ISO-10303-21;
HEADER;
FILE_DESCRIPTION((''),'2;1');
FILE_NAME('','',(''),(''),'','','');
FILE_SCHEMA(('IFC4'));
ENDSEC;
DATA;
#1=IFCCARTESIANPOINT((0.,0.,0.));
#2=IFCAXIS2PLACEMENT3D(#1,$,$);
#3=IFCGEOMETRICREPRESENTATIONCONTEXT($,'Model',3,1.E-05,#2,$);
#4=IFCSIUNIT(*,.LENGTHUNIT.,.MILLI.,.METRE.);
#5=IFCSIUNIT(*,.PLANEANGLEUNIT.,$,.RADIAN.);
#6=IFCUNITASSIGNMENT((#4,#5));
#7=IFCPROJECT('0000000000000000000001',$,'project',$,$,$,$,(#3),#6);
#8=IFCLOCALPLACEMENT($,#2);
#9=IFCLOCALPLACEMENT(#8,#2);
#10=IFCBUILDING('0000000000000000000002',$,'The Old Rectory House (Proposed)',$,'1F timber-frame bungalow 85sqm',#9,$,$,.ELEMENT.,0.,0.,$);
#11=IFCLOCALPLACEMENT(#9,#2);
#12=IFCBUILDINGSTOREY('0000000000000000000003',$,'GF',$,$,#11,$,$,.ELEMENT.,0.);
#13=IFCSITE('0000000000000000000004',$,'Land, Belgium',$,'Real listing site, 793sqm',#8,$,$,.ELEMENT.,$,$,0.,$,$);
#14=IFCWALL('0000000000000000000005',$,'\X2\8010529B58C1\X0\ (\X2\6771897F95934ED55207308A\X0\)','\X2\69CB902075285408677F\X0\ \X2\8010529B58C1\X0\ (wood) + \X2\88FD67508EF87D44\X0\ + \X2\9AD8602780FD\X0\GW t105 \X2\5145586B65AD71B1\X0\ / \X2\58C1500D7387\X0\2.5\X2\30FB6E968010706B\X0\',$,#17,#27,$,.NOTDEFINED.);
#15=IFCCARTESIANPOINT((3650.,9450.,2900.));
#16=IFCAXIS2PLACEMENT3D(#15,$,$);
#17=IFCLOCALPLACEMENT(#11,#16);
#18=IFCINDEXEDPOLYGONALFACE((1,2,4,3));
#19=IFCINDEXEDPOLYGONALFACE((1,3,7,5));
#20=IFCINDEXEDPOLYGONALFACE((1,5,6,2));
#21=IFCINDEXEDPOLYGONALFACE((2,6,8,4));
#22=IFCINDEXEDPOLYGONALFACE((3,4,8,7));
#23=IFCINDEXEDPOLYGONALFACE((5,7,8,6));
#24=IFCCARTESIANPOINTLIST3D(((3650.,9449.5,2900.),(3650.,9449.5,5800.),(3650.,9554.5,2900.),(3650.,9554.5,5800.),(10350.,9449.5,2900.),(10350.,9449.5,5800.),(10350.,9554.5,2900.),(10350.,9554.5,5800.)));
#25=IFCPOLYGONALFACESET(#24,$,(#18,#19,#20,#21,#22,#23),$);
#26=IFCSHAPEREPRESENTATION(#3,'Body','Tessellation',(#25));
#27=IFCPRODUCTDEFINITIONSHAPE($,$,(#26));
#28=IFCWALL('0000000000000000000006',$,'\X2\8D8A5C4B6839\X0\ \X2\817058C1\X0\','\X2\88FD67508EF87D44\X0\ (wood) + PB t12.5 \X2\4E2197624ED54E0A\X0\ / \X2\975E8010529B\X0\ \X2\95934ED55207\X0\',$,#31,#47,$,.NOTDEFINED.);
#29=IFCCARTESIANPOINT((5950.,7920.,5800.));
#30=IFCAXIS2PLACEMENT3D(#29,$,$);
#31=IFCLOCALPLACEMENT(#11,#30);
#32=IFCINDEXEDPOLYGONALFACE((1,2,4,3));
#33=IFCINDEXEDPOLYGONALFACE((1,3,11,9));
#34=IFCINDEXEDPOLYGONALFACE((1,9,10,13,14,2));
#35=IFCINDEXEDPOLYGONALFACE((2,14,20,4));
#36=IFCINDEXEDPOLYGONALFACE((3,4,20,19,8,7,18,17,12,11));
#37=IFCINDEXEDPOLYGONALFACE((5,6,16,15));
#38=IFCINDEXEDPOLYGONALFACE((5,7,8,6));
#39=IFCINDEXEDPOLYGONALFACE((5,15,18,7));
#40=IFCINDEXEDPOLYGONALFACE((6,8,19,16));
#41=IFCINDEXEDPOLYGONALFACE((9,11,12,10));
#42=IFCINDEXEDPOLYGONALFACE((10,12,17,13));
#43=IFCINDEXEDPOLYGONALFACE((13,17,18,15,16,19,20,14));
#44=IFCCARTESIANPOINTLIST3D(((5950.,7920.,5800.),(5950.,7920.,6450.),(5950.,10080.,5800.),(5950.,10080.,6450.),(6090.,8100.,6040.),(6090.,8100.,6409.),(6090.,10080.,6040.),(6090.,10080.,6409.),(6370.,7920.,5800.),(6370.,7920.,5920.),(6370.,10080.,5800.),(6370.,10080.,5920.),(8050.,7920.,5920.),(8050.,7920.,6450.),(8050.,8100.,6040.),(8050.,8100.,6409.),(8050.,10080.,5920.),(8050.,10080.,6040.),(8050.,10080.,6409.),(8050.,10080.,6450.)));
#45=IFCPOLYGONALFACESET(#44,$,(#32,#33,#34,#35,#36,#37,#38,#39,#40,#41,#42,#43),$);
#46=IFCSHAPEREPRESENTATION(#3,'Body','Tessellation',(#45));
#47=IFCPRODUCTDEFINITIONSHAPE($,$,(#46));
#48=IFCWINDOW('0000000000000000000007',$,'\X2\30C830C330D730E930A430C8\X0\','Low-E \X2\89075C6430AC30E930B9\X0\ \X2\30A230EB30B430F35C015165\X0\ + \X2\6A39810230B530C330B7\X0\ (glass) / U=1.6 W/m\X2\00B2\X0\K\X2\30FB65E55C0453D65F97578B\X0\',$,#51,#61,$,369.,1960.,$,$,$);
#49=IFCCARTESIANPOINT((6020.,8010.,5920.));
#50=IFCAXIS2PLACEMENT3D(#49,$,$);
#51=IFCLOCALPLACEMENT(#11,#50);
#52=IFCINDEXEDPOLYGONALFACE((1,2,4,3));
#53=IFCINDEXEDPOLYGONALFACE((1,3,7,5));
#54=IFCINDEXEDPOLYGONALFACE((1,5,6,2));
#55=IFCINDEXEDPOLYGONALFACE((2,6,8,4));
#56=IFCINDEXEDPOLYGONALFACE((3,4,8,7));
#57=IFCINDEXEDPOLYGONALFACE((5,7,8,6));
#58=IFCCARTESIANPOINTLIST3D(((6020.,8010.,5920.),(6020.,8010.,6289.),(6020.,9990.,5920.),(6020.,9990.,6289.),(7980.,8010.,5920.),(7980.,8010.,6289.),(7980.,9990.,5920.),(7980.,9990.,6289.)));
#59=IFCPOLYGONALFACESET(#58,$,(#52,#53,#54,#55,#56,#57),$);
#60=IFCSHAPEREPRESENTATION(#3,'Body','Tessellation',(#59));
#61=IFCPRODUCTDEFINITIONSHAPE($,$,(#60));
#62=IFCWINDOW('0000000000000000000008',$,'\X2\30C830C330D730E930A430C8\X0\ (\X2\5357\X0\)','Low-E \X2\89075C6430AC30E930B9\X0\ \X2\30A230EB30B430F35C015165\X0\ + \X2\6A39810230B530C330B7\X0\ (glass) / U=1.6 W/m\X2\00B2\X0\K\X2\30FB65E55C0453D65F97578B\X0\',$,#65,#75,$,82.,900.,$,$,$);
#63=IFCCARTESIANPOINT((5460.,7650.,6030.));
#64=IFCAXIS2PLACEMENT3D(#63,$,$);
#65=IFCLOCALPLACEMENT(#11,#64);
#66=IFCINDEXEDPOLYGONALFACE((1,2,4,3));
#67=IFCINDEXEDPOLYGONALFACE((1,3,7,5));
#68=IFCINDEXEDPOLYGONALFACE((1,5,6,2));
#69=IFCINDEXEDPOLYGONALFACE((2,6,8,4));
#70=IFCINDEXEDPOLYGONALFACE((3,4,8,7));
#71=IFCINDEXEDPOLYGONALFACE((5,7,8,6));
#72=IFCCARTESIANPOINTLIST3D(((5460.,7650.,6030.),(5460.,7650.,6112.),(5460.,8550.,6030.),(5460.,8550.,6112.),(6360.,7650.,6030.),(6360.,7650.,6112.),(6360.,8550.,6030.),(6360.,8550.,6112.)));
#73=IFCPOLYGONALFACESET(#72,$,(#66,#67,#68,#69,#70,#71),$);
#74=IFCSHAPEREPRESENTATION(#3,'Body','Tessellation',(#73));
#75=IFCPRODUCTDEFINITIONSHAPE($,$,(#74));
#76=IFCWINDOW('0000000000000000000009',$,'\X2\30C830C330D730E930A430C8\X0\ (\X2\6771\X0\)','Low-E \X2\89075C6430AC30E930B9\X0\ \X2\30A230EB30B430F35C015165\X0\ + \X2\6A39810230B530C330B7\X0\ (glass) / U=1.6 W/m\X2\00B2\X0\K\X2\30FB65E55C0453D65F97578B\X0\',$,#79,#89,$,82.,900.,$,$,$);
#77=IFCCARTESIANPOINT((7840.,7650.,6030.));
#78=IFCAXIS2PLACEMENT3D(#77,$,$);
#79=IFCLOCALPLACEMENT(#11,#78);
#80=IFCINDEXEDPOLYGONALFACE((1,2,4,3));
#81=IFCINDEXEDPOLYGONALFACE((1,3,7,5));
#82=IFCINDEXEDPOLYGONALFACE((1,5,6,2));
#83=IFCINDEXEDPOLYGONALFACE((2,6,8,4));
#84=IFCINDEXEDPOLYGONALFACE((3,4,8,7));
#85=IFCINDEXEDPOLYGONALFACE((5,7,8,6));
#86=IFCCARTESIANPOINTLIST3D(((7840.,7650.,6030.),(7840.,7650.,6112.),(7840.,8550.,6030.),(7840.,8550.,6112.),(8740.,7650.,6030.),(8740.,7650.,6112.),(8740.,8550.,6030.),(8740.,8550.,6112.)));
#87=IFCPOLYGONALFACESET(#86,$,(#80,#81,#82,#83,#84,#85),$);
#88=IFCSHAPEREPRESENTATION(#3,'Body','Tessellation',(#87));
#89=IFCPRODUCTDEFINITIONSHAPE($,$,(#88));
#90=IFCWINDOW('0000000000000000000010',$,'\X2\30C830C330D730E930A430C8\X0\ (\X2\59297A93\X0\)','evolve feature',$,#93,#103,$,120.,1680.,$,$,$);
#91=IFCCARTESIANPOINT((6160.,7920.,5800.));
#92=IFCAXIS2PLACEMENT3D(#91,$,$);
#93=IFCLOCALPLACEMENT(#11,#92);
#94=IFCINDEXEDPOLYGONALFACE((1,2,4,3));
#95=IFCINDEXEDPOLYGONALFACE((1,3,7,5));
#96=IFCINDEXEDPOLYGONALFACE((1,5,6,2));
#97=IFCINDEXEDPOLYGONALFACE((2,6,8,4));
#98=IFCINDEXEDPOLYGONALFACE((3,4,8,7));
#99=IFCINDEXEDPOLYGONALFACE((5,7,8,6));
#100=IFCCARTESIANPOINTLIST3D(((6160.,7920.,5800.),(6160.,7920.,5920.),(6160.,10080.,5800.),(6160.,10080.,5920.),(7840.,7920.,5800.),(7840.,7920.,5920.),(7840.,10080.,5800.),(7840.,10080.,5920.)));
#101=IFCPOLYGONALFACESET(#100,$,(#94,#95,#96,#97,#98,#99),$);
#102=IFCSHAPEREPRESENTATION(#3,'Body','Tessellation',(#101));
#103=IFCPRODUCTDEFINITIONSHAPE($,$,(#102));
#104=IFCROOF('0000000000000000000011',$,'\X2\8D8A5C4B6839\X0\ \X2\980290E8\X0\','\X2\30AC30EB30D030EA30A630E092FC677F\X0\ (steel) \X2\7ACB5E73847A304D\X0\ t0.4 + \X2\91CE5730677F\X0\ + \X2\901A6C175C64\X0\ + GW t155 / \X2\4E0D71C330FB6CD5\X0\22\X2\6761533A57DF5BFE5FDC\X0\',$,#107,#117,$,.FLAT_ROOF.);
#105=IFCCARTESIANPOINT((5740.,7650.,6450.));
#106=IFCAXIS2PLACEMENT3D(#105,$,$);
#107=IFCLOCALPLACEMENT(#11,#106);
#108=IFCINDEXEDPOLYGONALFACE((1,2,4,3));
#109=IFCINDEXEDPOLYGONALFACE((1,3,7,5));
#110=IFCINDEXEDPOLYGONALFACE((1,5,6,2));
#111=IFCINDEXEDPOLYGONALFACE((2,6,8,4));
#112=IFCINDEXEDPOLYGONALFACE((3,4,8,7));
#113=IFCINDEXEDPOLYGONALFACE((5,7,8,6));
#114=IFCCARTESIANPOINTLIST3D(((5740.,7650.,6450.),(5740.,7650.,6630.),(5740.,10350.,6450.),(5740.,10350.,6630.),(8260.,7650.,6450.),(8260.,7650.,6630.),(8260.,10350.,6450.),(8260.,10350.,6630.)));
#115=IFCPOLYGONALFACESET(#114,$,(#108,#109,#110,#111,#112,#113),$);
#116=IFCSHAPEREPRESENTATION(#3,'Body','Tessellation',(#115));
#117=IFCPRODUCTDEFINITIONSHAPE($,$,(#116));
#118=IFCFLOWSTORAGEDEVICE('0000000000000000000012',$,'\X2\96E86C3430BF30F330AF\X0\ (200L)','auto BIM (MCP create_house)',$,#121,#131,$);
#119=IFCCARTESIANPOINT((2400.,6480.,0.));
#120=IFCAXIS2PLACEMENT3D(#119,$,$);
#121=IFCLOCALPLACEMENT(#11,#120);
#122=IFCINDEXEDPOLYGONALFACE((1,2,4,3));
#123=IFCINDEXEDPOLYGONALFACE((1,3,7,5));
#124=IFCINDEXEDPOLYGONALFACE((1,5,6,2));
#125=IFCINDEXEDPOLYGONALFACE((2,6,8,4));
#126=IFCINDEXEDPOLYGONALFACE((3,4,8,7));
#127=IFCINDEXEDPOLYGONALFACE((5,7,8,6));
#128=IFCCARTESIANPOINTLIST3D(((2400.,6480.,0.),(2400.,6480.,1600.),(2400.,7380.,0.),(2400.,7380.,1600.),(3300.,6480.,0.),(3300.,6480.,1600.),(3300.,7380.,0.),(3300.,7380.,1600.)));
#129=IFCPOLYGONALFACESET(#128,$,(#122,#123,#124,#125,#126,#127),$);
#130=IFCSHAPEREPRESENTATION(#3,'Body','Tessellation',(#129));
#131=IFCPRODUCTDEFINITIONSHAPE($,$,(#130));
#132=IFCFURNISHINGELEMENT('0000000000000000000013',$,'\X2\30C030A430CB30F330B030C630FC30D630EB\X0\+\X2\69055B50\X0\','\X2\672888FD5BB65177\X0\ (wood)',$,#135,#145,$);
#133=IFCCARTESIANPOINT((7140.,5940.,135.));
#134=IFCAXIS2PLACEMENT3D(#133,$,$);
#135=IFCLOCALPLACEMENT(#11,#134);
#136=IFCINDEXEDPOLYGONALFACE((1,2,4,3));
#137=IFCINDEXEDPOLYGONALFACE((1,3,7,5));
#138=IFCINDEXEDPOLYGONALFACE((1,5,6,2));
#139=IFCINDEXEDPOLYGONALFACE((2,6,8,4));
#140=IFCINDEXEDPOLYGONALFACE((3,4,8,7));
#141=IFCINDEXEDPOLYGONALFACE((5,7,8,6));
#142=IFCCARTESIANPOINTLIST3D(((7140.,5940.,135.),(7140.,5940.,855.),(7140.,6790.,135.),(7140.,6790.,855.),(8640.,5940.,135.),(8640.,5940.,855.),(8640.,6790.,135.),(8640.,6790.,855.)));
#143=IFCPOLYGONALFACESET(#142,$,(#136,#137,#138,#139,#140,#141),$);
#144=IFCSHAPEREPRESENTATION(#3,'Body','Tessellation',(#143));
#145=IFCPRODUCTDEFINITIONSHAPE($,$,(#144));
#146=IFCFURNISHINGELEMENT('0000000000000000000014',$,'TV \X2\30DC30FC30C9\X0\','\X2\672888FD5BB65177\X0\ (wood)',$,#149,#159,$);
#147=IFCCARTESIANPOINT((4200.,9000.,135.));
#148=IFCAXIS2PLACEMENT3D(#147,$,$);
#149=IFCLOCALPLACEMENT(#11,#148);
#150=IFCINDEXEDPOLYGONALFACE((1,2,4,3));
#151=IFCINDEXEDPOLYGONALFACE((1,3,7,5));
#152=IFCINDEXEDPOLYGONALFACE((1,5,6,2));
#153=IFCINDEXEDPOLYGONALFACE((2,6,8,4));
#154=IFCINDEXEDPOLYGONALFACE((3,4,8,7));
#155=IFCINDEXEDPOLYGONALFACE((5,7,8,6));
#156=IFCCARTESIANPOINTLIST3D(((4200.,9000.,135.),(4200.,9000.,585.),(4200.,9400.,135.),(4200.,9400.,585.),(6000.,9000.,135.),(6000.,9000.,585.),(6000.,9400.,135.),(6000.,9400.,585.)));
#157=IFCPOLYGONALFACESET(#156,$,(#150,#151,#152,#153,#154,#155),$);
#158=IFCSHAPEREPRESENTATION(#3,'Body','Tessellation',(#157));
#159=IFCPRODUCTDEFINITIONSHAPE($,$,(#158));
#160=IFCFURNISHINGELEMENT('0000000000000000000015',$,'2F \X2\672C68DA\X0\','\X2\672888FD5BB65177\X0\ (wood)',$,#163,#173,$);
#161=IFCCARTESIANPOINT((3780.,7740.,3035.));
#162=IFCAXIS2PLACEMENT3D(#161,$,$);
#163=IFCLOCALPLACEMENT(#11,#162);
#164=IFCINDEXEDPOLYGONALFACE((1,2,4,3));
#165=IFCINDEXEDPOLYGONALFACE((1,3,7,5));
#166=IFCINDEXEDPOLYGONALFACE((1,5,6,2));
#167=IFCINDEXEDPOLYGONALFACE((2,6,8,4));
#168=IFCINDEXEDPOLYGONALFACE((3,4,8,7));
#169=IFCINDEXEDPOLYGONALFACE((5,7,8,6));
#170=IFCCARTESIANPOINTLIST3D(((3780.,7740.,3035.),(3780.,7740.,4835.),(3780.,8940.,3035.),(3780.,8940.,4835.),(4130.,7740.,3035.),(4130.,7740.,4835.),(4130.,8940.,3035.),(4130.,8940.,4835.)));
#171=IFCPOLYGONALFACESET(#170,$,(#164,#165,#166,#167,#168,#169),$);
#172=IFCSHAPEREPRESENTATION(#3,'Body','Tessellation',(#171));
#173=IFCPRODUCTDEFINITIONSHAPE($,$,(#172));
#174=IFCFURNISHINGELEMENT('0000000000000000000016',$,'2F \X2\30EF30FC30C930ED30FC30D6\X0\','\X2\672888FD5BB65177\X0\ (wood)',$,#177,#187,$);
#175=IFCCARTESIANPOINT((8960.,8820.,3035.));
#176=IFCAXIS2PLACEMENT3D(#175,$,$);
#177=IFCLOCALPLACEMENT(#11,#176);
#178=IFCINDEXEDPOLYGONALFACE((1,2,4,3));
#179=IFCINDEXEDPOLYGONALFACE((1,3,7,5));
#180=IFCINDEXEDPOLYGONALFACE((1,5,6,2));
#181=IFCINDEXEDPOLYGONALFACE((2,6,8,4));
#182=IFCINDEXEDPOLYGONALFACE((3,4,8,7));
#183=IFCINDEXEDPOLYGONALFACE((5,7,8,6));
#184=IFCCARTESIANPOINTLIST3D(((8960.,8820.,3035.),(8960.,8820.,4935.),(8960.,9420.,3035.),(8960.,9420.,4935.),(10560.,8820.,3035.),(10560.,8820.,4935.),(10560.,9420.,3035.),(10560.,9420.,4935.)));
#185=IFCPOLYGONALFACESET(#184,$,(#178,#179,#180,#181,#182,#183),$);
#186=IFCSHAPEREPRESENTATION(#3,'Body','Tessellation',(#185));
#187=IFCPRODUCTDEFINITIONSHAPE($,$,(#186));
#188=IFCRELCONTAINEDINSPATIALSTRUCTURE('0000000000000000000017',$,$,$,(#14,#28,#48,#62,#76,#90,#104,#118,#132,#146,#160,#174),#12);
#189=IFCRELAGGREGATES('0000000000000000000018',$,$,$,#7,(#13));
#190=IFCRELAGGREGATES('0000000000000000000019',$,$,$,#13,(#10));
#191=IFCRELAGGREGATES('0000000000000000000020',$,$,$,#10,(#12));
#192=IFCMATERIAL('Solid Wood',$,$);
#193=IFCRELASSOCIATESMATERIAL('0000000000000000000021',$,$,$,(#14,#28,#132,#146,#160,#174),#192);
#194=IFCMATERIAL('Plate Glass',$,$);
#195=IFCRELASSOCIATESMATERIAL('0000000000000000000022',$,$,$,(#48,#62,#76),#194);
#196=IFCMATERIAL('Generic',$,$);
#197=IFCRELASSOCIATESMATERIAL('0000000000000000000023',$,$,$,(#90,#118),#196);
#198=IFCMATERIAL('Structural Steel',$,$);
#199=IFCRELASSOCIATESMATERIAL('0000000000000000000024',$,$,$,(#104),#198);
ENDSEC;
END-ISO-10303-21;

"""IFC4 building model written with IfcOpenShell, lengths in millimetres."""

from ifc_helpers import new_model, si_unit, frame, frame_2d, origin, place, context, project, spatial, rectangle, extrude, material, element, fill, save


model = new_model("IFC4")

# Units and contexts
model_context = context("Model", 3, precision=1e-05, world=origin())
ifc_project = project(units=[si_unit("LENGTHUNIT", "METRE", prefix="MILLI"), si_unit("PLANEANGLEUNIT", "RADIAN")], contexts=[model_context])

# Site, building, storey
site_placement = place(None, origin())
site = spatial("IfcSite", under=ifc_project, at=site_placement, Name="Land, Belgium", ObjectType="Real listing site, 793sqm", CompositionType="ELEMENT", RefElevation=0.0)
building_placement = place(site_placement, origin())
building = spatial("IfcBuilding", under=site, at=building_placement, Name="The Old Rectory House (Proposed)", ObjectType="1F timber-frame bungalow 85sqm", CompositionType="ELEMENT", ElevationOfRefHeight=0.0, ElevationOfTerrain=0.0)
storey_placement = place(building_placement, origin())
storey = spatial("IfcBuildingStorey", under=building, at=storey_placement, Name="GF", CompositionType="ELEMENT", Elevation=0.0)

# Wall
ifc_material_1 = material(Name="Solid Wood")
wall_1_placement = place(storey_placement, frame((3650.0, 9450.0, 2900.0)))
element("IfcWall", 1, at=wall_1_placement, inside=storey, material=ifc_material_1, Name="耐力壁 (東西間仕切り)", Description="構造用合板 耐力壁 (wood) + 製材軸組 + 高性能GW t105 充填断熱 / 壁倍率2.5・準耐火", PredefinedType="NOTDEFINED", context=model_context, shape_type="SweptSolid", body=[
    extrude(rectangle(XDim=6700.0, YDim=105.0, at=frame_2d((3350.0, 52.0))), frame((3650.0, 9450.0, 2900.0)), (0.0, 0.0, 1.0), 2900.0),
])

# Wall, openings, windows
wall_2_placement = place(storey_placement, frame((5950.0, 7920.0, 5800.0)))
wall_2 = element("IfcWall", 2, at=wall_2_placement, inside=storey, material=ifc_material_1, Name="越屋根 腰壁", Description="製材軸組 (wood) + PB t12.5 両面仕上 / 非耐力 間仕切", PredefinedType="NOTDEFINED", context=model_context, shape_type="SweptSolid", body=[
    extrude(rectangle(XDim=2100.0, YDim=2160.0, at=frame_2d((1050.0, 1080.0))), frame((5950.0, 7920.0, 5800.0)), (0.0, 0.0, 1.0), 650.0),
])
opening_1_placement = place(storey_placement, frame((6020.0, 8010.0, 5920.0)))
opening_1 = element("IfcOpeningElement", 3, at=opening_1_placement, cuts=wall_2, PredefinedType="NOTDEFINED", context=model_context, shape_type="SweptSolid", body=[
    extrude(rectangle(XDim=1960.0, YDim=1980.0, at=frame_2d((980.0, 990.0))), frame((6020.0, 8010.0, 5920.0)), (0.0, 0.0, 1.0), 369.0),
])
opening_2_placement = place(storey_placement, frame((5460.0, 7650.0, 6030.0)))
opening_2 = element("IfcOpeningElement", 4, at=opening_2_placement, cuts=wall_2, PredefinedType="NOTDEFINED", context=model_context, shape_type="SweptSolid", body=[
    extrude(rectangle(XDim=900.0, YDim=900.0, at=frame_2d((450.0, 450.0))), frame((5460.0, 7650.0, 6030.0)), (0.0, 0.0, 1.0), 82.0),
])
opening_3_placement = place(storey_placement, frame((7840.0, 7650.0, 6030.0)))
opening_3 = element("IfcOpeningElement", 5, at=opening_3_placement, cuts=wall_2, PredefinedType="NOTDEFINED", context=model_context, shape_type="SweptSolid", body=[
    extrude(rectangle(XDim=900.0, YDim=900.0, at=frame_2d((450.0, 450.0))), frame((7840.0, 7650.0, 6030.0)), (0.0, 0.0, 1.0), 82.0),
])
opening_4_placement = place(storey_placement, frame((6160.0, 7920.0, 5800.0)))
opening_4 = element("IfcOpeningElement", 6, at=opening_4_placement, cuts=wall_2, PredefinedType="NOTDEFINED", context=model_context, shape_type="SweptSolid", body=[
    extrude(rectangle(XDim=1680.0, YDim=2160.0, at=frame_2d((840.0, 1080.0))), frame((6160.0, 7920.0, 5800.0)), (0.0, 0.0, 1.0), 120.0),
])
ifc_material_2 = material(Name="Plate Glass")
window_1_placement = place(storey_placement, frame((6020.0, 8010.0, 5920.0)))
window_1 = element("IfcWindow", 7, at=window_1_placement, inside=storey, material=ifc_material_2, Name="トップライト", Description="Low-E 複層ガラス アルゴン封入 + 樹脂サッシ (glass) / U=1.6 W/m²K・日射取得型", OverallHeight=369.0, OverallWidth=1960.0, context=model_context, shape_type="SweptSolid", body=[
    extrude(rectangle(XDim=1960.0, YDim=1980.0, at=frame_2d((980.0, 990.0))), frame((6020.0, 8010.0, 5920.0)), (0.0, 0.0, 1.0), 369.0),
])
fill(opening_1, window_1)
window_2_placement = place(storey_placement, frame((5460.0, 7650.0, 6030.0)))
window_2 = element("IfcWindow", 8, at=window_2_placement, inside=storey, material=ifc_material_2, Name="トップライト (南)", Description="Low-E 複層ガラス アルゴン封入 + 樹脂サッシ (glass) / U=1.6 W/m²K・日射取得型", OverallHeight=82.0, OverallWidth=900.0, context=model_context, shape_type="SweptSolid", body=[
    extrude(rectangle(XDim=900.0, YDim=900.0, at=frame_2d((450.0, 450.0))), frame((5460.0, 7650.0, 6030.0)), (0.0, 0.0, 1.0), 82.0),
])
fill(opening_2, window_2)
window_3_placement = place(storey_placement, frame((7840.0, 7650.0, 6030.0)))
window_3 = element("IfcWindow", 9, at=window_3_placement, inside=storey, material=ifc_material_2, Name="トップライト (東)", Description="Low-E 複層ガラス アルゴン封入 + 樹脂サッシ (glass) / U=1.6 W/m²K・日射取得型", OverallHeight=82.0, OverallWidth=900.0, context=model_context, shape_type="SweptSolid", body=[
    extrude(rectangle(XDim=900.0, YDim=900.0, at=frame_2d((450.0, 450.0))), frame((7840.0, 7650.0, 6030.0)), (0.0, 0.0, 1.0), 82.0),
])
fill(opening_3, window_3)
ifc_material_3 = material(Name="Generic")
window_4_placement = place(storey_placement, frame((6160.0, 7920.0, 5800.0)))
window_4 = element("IfcWindow", 10, at=window_4_placement, inside=storey, material=ifc_material_3, Name="トップライト (天窓)", Description="evolve feature", OverallHeight=120.0, OverallWidth=1680.0, context=model_context, shape_type="SweptSolid", body=[
    extrude(rectangle(XDim=1680.0, YDim=2160.0, at=frame_2d((840.0, 1080.0))), frame((6160.0, 7920.0, 5800.0)), (0.0, 0.0, 1.0), 120.0),
])
fill(opening_4, window_4)

# Roof
ifc_material_4 = material(Name="Structural Steel")
roof_placement = place(storey_placement, frame((5740.0, 7650.0, 6450.0)))
element("IfcRoof", 11, at=roof_placement, inside=storey, material=ifc_material_4, Name="越屋根 頂部", Description="ガルバリウム鋼板 (steel) 立平葺き t0.4 + 野地板 + 通気層 + GW t155 / 不燃・法22条区域対応", PredefinedType="FLAT_ROOF", context=model_context, shape_type="SweptSolid", body=[
    extrude(rectangle(XDim=2520.0, YDim=2700.0, at=frame_2d((1260.0, 1350.0))), frame((5740.0, 7650.0, 6450.0)), (0.0, 0.0, 1.0), 180.0),
])

# Flow storage device
flow_storage_device_placement = place(storey_placement, frame((2400.0, 6480.0, 0.0)))
element("IfcFlowStorageDevice", 12, at=flow_storage_device_placement, inside=storey, material=ifc_material_3, Name="雨水タンク (200L)", Description="auto BIM (MCP create_house)", context=model_context, shape_type="SweptSolid", body=[
    extrude(rectangle(XDim=900.0, YDim=900.0, at=frame_2d((450.0, 450.0))), frame((2400.0, 6480.0, 0.0)), (0.0, 0.0, 1.0), 1600.0),
])

# Furnishing elements
furnishing_1_placement = place(storey_placement, frame((7140.0, 5940.0, 135.0)))
element("IfcFurnishingElement", 13, at=furnishing_1_placement, inside=storey, material=ifc_material_1, Name="ダイニングテーブル+椅子", Description="木製家具 (wood)", context=model_context, shape_type="SweptSolid", body=[
    extrude(rectangle(XDim=1500.0, YDim=850.0, at=frame_2d((750.0, 425.0))), frame((7140.0, 5940.0, 135.0)), (0.0, 0.0, 1.0), 720.0),
])
furnishing_2_placement = place(storey_placement, frame((4200.0, 9000.0, 135.0)))
element("IfcFurnishingElement", 14, at=furnishing_2_placement, inside=storey, material=ifc_material_1, Name="TV ボード", Description="木製家具 (wood)", context=model_context, shape_type="SweptSolid", body=[
    extrude(rectangle(XDim=1800.0, YDim=400.0, at=frame_2d((900.0, 200.0))), frame((4200.0, 9000.0, 135.0)), (0.0, 0.0, 1.0), 450.0),
])
furnishing_3_placement = place(storey_placement, frame((3780.0, 7740.0, 3035.0)))
element("IfcFurnishingElement", 15, at=furnishing_3_placement, inside=storey, material=ifc_material_1, Name="2F 本棚", Description="木製家具 (wood)", context=model_context, shape_type="SweptSolid", body=[
    extrude(rectangle(XDim=350.0, YDim=1200.0, at=frame_2d((175.0, 600.0))), frame((3780.0, 7740.0, 3035.0)), (0.0, 0.0, 1.0), 1800.0),
])
furnishing_4_placement = place(storey_placement, frame((8960.0, 8820.0, 3035.0)))
element("IfcFurnishingElement", 16, at=furnishing_4_placement, inside=storey, material=ifc_material_1, Name="2F ワードローブ", Description="木製家具 (wood)", context=model_context, shape_type="SweptSolid", body=[
    extrude(rectangle(XDim=1600.0, YDim=600.0, at=frame_2d((800.0, 300.0))), frame((8960.0, 8820.0, 3035.0)), (0.0, 0.0, 1.0), 1900.0),
])

save(model, "model.ifc")
